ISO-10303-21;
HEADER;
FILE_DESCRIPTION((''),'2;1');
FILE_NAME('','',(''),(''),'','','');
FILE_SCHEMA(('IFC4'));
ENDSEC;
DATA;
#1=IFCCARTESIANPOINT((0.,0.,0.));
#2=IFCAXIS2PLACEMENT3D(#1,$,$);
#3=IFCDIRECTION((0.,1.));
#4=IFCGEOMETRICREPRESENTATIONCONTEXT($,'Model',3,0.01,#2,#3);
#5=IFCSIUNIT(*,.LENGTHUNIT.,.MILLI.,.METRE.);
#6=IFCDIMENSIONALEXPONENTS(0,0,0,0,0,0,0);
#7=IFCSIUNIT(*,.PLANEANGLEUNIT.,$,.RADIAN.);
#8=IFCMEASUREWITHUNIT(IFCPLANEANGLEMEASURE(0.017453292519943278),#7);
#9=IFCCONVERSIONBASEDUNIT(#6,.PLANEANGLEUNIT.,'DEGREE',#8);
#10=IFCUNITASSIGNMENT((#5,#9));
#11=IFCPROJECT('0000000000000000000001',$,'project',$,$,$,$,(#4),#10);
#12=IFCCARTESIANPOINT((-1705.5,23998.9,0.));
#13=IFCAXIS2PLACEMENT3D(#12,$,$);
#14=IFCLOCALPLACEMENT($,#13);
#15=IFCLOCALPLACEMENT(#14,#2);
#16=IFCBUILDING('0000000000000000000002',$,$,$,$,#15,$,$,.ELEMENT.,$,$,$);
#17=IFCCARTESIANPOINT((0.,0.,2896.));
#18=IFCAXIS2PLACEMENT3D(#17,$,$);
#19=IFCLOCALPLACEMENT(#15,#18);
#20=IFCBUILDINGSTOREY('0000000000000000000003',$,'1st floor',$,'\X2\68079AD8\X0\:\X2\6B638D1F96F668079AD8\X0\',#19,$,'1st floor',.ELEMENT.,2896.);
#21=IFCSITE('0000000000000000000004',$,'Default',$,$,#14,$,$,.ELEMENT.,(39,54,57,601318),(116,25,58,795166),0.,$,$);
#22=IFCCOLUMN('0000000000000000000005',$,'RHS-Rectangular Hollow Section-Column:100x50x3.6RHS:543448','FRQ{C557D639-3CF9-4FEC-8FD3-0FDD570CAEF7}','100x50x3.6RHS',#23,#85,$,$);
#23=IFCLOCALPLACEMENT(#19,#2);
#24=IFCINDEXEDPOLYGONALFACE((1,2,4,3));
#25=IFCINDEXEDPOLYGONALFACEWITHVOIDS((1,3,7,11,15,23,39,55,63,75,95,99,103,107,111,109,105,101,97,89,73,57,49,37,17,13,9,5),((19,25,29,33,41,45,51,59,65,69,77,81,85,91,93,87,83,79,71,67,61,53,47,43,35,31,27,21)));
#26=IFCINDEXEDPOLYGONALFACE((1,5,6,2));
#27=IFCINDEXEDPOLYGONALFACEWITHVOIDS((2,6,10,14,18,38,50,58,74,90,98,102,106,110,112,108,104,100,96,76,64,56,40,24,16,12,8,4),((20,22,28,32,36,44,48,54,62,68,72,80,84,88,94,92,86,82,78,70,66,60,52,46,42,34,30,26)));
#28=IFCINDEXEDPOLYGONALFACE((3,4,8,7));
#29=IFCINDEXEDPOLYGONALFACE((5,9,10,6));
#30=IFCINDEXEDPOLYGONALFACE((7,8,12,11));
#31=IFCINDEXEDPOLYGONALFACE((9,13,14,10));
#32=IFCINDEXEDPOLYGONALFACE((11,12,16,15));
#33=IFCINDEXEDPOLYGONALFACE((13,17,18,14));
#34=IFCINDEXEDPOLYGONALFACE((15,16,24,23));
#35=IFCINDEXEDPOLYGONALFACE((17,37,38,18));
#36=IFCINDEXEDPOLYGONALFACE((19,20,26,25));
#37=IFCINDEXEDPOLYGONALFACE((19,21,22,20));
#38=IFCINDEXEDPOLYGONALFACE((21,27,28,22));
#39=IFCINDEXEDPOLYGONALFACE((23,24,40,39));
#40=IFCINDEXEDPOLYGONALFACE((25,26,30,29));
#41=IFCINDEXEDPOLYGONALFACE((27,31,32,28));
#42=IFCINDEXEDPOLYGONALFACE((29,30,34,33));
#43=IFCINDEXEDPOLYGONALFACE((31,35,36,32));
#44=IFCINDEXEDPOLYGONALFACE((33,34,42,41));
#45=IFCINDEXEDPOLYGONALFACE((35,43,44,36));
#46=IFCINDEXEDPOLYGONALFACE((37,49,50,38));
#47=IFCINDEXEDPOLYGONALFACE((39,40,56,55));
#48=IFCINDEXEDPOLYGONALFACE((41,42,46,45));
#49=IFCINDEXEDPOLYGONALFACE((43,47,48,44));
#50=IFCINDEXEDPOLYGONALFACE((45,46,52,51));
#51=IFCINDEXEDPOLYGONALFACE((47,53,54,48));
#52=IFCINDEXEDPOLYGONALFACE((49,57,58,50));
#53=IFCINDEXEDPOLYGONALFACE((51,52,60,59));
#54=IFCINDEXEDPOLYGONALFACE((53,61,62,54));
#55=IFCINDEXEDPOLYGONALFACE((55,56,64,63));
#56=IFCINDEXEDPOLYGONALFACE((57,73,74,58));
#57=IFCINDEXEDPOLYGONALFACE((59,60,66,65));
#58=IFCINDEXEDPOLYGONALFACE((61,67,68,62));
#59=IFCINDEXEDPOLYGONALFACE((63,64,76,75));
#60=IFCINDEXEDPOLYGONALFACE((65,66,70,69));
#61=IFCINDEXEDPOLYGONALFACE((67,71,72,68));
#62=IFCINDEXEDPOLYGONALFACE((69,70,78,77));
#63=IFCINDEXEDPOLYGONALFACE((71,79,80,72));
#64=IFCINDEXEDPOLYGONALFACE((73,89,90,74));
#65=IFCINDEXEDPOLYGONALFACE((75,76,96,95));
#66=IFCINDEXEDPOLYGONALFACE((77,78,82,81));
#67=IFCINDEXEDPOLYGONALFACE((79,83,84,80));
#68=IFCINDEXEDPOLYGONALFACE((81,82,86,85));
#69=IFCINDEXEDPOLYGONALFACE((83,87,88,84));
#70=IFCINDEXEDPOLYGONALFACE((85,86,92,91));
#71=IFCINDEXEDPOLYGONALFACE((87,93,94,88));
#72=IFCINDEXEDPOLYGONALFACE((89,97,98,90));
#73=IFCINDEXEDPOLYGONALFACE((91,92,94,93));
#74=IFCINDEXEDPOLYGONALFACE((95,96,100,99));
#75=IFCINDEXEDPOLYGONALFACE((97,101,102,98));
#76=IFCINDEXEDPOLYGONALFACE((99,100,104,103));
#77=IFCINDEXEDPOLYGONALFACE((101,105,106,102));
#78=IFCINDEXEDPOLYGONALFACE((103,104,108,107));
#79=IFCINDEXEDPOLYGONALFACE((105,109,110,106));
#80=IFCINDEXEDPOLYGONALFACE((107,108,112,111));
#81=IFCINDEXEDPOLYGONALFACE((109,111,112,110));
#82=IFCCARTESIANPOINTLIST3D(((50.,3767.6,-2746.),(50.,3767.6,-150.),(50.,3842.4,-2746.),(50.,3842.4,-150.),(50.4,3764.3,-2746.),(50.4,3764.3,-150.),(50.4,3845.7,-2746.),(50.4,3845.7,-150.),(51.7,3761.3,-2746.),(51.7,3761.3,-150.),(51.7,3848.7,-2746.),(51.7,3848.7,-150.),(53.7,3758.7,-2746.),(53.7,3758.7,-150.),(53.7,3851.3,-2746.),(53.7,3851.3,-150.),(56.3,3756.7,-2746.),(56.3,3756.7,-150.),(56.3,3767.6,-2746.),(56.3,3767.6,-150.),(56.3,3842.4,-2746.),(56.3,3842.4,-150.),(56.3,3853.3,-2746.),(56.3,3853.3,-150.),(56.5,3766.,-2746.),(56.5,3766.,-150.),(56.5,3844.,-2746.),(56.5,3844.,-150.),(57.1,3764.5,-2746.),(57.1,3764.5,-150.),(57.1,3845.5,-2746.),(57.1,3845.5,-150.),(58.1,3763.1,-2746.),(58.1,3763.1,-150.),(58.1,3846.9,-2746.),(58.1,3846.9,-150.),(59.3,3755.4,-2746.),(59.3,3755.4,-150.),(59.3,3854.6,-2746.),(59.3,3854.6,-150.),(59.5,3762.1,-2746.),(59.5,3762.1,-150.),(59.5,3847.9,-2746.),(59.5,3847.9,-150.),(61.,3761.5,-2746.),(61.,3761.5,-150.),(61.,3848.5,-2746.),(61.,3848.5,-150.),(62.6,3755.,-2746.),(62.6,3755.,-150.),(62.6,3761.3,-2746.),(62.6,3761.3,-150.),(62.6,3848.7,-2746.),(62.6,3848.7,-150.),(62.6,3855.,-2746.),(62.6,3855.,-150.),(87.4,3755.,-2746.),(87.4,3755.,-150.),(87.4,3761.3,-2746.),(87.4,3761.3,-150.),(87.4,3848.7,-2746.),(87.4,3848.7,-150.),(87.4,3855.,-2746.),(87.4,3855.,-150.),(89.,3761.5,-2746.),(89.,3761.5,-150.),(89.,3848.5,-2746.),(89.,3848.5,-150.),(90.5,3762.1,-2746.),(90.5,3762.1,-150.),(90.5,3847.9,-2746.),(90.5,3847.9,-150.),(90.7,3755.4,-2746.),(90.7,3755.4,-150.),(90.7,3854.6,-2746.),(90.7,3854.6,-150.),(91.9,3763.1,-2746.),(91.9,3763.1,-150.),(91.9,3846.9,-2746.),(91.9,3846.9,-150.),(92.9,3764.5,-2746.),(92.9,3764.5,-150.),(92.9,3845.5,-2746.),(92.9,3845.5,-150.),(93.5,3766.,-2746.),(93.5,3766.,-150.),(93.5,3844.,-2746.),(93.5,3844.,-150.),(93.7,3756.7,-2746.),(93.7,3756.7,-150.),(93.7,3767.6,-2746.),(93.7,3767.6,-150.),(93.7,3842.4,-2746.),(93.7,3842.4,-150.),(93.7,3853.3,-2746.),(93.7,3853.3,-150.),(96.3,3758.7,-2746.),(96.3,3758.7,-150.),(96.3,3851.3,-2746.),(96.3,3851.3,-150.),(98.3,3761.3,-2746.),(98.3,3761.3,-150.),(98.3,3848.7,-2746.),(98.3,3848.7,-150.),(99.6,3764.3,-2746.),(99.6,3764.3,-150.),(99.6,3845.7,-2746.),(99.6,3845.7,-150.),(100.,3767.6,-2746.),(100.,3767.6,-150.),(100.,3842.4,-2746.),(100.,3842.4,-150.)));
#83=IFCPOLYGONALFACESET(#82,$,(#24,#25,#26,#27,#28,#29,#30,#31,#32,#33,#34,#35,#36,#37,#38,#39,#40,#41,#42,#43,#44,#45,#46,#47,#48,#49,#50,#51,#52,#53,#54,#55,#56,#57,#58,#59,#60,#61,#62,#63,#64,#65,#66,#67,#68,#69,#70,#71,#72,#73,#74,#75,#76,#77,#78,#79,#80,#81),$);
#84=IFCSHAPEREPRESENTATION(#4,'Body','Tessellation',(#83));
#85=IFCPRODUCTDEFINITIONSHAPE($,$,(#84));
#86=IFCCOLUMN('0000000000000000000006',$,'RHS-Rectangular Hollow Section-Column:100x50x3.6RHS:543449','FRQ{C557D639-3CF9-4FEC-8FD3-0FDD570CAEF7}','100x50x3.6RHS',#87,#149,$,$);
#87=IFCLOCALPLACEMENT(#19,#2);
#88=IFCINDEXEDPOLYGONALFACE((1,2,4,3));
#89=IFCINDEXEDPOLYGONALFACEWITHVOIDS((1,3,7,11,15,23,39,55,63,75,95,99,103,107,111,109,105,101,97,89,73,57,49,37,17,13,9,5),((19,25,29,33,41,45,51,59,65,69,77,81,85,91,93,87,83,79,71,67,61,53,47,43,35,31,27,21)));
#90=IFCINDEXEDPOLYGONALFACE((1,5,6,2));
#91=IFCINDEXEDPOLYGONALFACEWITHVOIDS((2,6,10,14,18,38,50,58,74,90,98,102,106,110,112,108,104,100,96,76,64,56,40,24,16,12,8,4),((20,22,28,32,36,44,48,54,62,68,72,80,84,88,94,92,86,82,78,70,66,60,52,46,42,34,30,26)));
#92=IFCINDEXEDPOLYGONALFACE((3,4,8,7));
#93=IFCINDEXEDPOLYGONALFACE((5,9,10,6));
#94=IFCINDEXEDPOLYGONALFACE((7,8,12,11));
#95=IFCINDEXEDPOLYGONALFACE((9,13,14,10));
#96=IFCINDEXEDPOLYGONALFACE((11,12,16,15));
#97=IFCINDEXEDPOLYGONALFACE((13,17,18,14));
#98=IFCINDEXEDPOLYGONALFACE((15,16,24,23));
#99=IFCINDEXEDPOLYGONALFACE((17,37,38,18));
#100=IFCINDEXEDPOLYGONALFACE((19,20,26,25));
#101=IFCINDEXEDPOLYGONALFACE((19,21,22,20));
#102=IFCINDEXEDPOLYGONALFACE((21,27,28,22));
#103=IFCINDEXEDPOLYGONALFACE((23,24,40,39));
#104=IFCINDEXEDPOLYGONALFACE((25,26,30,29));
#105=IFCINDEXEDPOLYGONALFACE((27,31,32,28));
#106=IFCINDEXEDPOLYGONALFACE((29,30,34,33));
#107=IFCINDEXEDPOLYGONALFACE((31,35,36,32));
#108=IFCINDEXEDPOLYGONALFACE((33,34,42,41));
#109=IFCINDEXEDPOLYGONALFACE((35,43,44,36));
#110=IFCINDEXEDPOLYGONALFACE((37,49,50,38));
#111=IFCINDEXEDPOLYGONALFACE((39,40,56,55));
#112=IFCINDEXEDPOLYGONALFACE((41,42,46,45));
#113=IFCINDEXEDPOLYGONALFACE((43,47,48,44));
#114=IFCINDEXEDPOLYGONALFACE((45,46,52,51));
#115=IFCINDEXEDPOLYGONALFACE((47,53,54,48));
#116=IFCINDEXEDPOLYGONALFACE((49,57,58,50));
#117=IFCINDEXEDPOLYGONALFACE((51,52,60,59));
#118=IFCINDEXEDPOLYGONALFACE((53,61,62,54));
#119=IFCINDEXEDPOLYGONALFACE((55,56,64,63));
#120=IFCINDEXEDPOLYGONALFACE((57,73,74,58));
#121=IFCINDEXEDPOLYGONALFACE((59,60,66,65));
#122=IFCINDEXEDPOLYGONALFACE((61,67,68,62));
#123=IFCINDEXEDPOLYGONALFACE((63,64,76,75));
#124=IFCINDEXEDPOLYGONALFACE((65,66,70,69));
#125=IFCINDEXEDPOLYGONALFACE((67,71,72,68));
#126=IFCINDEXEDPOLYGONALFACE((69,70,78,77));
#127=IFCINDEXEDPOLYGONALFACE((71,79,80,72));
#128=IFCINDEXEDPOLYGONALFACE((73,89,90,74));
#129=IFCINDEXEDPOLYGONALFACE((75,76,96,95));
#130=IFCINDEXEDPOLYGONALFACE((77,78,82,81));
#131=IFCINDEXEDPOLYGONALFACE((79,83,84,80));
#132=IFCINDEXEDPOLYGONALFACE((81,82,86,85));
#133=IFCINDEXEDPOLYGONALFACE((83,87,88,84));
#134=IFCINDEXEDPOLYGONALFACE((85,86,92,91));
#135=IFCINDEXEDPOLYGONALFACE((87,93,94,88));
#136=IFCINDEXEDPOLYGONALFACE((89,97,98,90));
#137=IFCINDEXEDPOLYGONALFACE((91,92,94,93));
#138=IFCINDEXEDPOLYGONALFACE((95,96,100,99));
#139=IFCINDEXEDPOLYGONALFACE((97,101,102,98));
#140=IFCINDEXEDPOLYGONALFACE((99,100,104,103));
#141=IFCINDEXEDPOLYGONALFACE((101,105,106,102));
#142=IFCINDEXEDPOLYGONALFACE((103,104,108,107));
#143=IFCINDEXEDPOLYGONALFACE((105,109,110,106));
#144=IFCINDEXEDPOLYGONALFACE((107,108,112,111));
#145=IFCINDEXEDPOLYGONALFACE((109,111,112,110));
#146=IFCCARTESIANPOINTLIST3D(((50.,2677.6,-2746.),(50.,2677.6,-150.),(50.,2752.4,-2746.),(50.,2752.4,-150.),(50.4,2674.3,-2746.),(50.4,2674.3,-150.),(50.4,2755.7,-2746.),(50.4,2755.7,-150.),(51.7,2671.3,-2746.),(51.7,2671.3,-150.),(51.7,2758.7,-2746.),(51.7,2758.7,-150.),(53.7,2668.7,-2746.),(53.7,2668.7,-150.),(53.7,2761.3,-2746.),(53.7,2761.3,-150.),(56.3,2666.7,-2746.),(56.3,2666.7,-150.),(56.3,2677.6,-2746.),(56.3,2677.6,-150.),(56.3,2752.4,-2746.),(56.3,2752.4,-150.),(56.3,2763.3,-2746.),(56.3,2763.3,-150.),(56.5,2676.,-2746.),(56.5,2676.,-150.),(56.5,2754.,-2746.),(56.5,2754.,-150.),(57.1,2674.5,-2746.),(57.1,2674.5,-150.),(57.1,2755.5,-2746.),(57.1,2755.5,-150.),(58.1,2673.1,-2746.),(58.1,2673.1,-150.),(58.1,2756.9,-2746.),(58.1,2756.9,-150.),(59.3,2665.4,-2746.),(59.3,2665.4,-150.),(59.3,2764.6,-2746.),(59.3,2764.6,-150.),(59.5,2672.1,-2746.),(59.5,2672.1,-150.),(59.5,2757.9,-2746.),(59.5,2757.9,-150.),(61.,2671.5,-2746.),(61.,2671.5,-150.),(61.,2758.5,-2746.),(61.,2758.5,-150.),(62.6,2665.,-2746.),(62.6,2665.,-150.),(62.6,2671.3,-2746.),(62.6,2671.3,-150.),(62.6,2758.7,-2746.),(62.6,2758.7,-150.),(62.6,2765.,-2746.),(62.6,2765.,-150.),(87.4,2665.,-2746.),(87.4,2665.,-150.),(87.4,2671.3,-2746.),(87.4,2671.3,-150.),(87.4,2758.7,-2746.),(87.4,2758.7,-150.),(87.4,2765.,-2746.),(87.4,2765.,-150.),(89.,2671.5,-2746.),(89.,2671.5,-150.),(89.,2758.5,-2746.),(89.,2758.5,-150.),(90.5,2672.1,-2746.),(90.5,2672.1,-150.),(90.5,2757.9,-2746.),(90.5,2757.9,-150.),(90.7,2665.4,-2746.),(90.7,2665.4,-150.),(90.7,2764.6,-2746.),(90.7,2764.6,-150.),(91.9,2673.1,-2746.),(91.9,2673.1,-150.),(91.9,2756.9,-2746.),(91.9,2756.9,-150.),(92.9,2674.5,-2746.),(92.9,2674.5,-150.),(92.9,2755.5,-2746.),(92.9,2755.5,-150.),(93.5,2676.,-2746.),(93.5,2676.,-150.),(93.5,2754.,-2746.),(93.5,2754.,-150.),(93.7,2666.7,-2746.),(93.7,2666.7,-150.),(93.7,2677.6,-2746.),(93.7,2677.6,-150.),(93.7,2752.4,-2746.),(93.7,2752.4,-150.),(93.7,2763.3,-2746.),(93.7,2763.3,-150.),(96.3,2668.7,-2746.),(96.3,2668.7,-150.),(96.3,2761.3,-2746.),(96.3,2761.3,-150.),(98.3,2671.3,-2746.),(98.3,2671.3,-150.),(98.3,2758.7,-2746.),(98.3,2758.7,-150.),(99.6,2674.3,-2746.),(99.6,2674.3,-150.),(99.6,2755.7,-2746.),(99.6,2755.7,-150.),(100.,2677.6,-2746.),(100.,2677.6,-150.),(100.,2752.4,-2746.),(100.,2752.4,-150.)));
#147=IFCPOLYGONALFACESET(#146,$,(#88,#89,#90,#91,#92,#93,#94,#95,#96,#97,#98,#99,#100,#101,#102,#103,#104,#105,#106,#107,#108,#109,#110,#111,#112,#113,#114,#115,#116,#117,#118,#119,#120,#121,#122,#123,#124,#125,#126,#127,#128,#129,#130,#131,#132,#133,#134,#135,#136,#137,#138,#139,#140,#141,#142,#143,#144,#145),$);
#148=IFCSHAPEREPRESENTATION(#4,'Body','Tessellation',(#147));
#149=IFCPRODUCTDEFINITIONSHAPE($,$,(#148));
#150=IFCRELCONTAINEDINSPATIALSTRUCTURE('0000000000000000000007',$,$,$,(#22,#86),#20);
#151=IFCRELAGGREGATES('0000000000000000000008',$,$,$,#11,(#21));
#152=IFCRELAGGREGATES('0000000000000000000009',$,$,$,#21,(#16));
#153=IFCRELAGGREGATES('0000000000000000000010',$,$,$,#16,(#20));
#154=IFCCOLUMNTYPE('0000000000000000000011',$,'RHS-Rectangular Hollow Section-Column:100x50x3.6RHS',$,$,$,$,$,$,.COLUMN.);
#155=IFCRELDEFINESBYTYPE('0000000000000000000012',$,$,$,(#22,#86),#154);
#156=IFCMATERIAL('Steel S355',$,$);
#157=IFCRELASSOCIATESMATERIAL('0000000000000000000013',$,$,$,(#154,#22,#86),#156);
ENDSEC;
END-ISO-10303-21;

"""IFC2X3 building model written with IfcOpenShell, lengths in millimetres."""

from ifc_helpers import new_model, entity, si_unit, converted_unit, direction, frame, origin, origin_2d, place, context, project, spatial, hollow_rectangle, extrude, clip, halfspace, material, type_object, element, save


model = new_model("IFC2X3")

# Units and contexts
model_context = context("Model", 3, precision=0.01, world=origin(), true_north=direction((0.0, 1.0)))
ifc_project = project(units=[si_unit("LENGTHUNIT", "METRE", prefix="MILLI"), converted_unit("PLANEANGLEUNIT", "DEGREE", entity("IfcPlaneAngleMeasure", 0.017453292519943278), si_unit("PLANEANGLEUNIT", "RADIAN"), dimensions=[0, 0, 0, 0, 0, 0, 0])], contexts=[model_context])

# Site, building, storey
site_placement = place(None, frame((-1705.5, 23998.9, 0.0)))
site = spatial("IfcSite", under=ifc_project, at=site_placement, Name="Default", CompositionType="ELEMENT", RefLatitude=(39, 54, 57, 601318), RefLongitude=(116, 25, 58, 795166), RefElevation=0.0)
building_placement = place(site_placement, origin())
building = spatial("IfcBuilding", under=site, at=building_placement, CompositionType="ELEMENT")
storey_placement = place(building_placement, frame((0.0, 0.0, 2896.0)))
storey = spatial("IfcBuildingStorey", under=building, at=storey_placement, Name="1st floor", ObjectType="标高:正负零标高", LongName="1st floor", CompositionType="ELEMENT", Elevation=2896.0)

# Columns
ifc_material_1 = material(Name="Steel S355")
column_type_1 = type_object("IfcColumnType", Name="RHS-Rectangular Hollow Section-Column:100x50x3.6RHS", PredefinedType="COLUMN", material=ifc_material_1)
column_1_placement = place(storey_placement, frame((75.0, 3805.0, -150.0), z_axis=(0.0, 0.0, 1.0), x_axis=(-1.0, 0.0, 0.0)))
element("IfcColumn", 1, at=column_1_placement, inside=storey, type_object=column_type_1, material=ifc_material_1, Name="RHS-Rectangular Hollow Section-Column:100x50x3.6RHS:543448", Description="FRQ{C557D639-3CF9-4FEC-8FD3-0FDD570CAEF7}", ObjectType="100x50x3.6RHS", context=model_context, shape_type="Clipping", body=[
    clip(extrude(hollow_rectangle(XDim=50.0, YDim=100.0, WallThickness=6.3, InnerFilletRadius=6.3, OuterFilletRadius=12.6, at=origin_2d()), origin(), (0.0, 0.0, -1.0), 2651.9), halfspace(frame((75.0, 3805.0, -2596.0), z_axis=(0.0, 0.0, 1.0), x_axis=(-1.0, 0.0, 0.0)), True)),
])
column_2_placement = place(storey_placement, frame((75.0, 2715.0, -150.0), z_axis=(0.0, 0.0, 1.0), x_axis=(-1.0, 0.0, 0.0)))
element("IfcColumn", 2, at=column_2_placement, inside=storey, type_object=column_type_1, material=ifc_material_1, Name="RHS-Rectangular Hollow Section-Column:100x50x3.6RHS:543449", Description="FRQ{C557D639-3CF9-4FEC-8FD3-0FDD570CAEF7}", ObjectType="100x50x3.6RHS", context=model_context, shape_type="Clipping", body=[
    clip(extrude(hollow_rectangle(XDim=50.0, YDim=100.0, WallThickness=6.3, InnerFilletRadius=6.3, OuterFilletRadius=12.6, at=origin_2d()), origin(), (0.0, 0.0, -1.0), 2651.9), halfspace(frame((75.0, 2715.0, -2596.0), z_axis=(0.0, 0.0, 1.0), x_axis=(-1.0, 0.0, 0.0)), True)),
])

save(model, "model.ifc")
